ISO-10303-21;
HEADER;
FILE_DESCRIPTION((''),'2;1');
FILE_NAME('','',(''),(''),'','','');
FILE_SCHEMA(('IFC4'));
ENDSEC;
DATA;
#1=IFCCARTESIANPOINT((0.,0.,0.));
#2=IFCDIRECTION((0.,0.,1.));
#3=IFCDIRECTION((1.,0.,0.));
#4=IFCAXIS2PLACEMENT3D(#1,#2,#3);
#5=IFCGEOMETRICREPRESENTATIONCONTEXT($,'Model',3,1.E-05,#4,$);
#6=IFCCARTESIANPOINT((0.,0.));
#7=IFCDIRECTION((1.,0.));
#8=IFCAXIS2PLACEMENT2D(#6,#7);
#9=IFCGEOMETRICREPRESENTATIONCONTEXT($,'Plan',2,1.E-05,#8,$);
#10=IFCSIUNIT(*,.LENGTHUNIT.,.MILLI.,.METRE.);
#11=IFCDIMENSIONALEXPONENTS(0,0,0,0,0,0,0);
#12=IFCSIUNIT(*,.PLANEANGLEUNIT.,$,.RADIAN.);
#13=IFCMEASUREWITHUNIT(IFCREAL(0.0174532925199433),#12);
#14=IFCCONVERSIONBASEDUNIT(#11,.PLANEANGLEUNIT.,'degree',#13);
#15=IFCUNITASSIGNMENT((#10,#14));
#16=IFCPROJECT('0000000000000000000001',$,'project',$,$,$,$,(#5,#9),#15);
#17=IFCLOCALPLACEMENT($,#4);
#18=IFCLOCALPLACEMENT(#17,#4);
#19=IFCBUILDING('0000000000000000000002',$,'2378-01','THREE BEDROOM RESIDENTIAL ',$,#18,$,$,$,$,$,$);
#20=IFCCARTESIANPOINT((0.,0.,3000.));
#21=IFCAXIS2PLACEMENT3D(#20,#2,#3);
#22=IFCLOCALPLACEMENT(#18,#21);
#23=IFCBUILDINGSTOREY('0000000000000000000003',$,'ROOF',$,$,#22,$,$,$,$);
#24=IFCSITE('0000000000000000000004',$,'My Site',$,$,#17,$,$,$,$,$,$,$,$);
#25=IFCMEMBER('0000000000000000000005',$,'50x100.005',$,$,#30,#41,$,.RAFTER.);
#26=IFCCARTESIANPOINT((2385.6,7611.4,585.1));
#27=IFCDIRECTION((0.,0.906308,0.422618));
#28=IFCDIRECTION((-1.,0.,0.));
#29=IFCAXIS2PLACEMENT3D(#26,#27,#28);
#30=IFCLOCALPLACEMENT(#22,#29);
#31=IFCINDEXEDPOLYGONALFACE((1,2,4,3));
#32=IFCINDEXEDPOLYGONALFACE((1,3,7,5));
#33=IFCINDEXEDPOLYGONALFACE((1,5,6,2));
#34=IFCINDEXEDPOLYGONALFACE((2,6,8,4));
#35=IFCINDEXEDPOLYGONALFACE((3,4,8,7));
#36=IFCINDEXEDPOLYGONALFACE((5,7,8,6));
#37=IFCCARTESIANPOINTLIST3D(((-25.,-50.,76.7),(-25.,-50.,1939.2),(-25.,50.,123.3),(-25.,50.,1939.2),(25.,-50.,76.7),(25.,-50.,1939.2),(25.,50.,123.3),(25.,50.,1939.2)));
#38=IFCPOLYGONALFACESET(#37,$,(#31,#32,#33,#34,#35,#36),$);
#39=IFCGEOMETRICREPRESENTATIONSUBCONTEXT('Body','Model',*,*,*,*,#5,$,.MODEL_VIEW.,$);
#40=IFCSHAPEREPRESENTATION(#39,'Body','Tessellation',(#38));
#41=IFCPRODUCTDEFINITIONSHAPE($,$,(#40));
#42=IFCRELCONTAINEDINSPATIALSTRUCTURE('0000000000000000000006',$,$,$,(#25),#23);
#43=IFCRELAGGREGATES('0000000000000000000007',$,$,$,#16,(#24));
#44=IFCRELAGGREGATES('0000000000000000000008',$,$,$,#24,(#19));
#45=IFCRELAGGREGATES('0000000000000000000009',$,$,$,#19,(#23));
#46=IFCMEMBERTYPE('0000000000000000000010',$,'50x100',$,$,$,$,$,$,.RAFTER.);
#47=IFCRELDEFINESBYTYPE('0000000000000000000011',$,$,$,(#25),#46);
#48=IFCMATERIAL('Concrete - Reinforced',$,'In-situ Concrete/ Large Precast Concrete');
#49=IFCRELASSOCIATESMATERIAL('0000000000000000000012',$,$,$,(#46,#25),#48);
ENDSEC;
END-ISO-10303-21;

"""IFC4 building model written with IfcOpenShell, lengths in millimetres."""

from ifc_helpers import new_model, entity, si_unit, converted_unit, frame, origin_with_axes, origin_2d_with_axis, place, context, subcontext, project, spatial, rectangle, extrude, clip, halfspace, material, material_profile, profile_set, profile_usage, type_object, element, save


model = new_model("IFC4")

# Units and contexts
model_context = context("Model", 3, precision=1e-05, world=origin_with_axes())
plan_context = context("Plan", 2, precision=1e-05, world=origin_2d_with_axis())
body_context = subcontext(model_context, "Body", "Model", "MODEL_VIEW")
ifc_project = project(units=[si_unit("LENGTHUNIT", "METRE", prefix="MILLI"), converted_unit("PLANEANGLEUNIT", "degree", entity("IfcReal", 0.0174532925199433), si_unit("PLANEANGLEUNIT", "RADIAN"), dimensions=[0, 0, 0, 0, 0, 0, 0])], contexts=[model_context, plan_context])

# Site, building, storey
site_placement = place(None, origin_with_axes())
site = spatial("IfcSite", under=ifc_project, at=site_placement, Name="My Site")
building_placement = place(site_placement, origin_with_axes())
building = spatial("IfcBuilding", under=site, at=building_placement, Name="2378-01", Description="THREE BEDROOM RESIDENTIAL ")
storey_placement = place(building_placement, frame((0.0, 0.0, 3000.0), z_axis=(0.0, 0.0, 1.0), x_axis=(1.0, 0.0, 0.0)))
storey = spatial("IfcBuildingStorey", under=building, at=storey_placement, Name="ROOF")

# Member
ifc_material_1 = material(Name="Concrete - Reinforced", Category="In-situ Concrete/ Large Precast Concrete")
ifc_material_profile_1 = material_profile(ifc_material_1, rectangle(XDim=50.0, YDim=100.0), Name="Core Layer", Category="LoadBearing", Priority=1)
ifc_profile_set_1 = profile_set([ifc_material_profile_1], Name="wood")
member_type_1 = type_object("IfcMemberType", Name="50x100", PredefinedType="RAFTER", material=ifc_profile_set_1)
ifc_profile_usage_1 = profile_usage(ifc_profile_set_1, cardinal=5)
member_1_placement = place(storey_placement, frame((2385.6, 7611.4, 585.1), z_axis=(0.0, 0.906308, 0.422618), x_axis=(-1.0, 0.0, 0.0)))
element("IfcMember", 1, at=member_1_placement, inside=storey, type_object=member_type_1, material=ifc_profile_usage_1, Name="50x100.005", PredefinedType="RAFTER", context=body_context, shape_type="Clipping", body=[
    clip(extrude(rectangle(XDim=50.0, YDim=100.0), origin_with_axes(), (0.0, 0.0, 1.0), 1939.2), halfspace(frame((65.6, -20.4, 90.5), z_axis=(0.0, 0.422618, -0.906308), x_axis=(1.0, 0.0, 0.0)), False)),
])

save(model, "model.ifc")
